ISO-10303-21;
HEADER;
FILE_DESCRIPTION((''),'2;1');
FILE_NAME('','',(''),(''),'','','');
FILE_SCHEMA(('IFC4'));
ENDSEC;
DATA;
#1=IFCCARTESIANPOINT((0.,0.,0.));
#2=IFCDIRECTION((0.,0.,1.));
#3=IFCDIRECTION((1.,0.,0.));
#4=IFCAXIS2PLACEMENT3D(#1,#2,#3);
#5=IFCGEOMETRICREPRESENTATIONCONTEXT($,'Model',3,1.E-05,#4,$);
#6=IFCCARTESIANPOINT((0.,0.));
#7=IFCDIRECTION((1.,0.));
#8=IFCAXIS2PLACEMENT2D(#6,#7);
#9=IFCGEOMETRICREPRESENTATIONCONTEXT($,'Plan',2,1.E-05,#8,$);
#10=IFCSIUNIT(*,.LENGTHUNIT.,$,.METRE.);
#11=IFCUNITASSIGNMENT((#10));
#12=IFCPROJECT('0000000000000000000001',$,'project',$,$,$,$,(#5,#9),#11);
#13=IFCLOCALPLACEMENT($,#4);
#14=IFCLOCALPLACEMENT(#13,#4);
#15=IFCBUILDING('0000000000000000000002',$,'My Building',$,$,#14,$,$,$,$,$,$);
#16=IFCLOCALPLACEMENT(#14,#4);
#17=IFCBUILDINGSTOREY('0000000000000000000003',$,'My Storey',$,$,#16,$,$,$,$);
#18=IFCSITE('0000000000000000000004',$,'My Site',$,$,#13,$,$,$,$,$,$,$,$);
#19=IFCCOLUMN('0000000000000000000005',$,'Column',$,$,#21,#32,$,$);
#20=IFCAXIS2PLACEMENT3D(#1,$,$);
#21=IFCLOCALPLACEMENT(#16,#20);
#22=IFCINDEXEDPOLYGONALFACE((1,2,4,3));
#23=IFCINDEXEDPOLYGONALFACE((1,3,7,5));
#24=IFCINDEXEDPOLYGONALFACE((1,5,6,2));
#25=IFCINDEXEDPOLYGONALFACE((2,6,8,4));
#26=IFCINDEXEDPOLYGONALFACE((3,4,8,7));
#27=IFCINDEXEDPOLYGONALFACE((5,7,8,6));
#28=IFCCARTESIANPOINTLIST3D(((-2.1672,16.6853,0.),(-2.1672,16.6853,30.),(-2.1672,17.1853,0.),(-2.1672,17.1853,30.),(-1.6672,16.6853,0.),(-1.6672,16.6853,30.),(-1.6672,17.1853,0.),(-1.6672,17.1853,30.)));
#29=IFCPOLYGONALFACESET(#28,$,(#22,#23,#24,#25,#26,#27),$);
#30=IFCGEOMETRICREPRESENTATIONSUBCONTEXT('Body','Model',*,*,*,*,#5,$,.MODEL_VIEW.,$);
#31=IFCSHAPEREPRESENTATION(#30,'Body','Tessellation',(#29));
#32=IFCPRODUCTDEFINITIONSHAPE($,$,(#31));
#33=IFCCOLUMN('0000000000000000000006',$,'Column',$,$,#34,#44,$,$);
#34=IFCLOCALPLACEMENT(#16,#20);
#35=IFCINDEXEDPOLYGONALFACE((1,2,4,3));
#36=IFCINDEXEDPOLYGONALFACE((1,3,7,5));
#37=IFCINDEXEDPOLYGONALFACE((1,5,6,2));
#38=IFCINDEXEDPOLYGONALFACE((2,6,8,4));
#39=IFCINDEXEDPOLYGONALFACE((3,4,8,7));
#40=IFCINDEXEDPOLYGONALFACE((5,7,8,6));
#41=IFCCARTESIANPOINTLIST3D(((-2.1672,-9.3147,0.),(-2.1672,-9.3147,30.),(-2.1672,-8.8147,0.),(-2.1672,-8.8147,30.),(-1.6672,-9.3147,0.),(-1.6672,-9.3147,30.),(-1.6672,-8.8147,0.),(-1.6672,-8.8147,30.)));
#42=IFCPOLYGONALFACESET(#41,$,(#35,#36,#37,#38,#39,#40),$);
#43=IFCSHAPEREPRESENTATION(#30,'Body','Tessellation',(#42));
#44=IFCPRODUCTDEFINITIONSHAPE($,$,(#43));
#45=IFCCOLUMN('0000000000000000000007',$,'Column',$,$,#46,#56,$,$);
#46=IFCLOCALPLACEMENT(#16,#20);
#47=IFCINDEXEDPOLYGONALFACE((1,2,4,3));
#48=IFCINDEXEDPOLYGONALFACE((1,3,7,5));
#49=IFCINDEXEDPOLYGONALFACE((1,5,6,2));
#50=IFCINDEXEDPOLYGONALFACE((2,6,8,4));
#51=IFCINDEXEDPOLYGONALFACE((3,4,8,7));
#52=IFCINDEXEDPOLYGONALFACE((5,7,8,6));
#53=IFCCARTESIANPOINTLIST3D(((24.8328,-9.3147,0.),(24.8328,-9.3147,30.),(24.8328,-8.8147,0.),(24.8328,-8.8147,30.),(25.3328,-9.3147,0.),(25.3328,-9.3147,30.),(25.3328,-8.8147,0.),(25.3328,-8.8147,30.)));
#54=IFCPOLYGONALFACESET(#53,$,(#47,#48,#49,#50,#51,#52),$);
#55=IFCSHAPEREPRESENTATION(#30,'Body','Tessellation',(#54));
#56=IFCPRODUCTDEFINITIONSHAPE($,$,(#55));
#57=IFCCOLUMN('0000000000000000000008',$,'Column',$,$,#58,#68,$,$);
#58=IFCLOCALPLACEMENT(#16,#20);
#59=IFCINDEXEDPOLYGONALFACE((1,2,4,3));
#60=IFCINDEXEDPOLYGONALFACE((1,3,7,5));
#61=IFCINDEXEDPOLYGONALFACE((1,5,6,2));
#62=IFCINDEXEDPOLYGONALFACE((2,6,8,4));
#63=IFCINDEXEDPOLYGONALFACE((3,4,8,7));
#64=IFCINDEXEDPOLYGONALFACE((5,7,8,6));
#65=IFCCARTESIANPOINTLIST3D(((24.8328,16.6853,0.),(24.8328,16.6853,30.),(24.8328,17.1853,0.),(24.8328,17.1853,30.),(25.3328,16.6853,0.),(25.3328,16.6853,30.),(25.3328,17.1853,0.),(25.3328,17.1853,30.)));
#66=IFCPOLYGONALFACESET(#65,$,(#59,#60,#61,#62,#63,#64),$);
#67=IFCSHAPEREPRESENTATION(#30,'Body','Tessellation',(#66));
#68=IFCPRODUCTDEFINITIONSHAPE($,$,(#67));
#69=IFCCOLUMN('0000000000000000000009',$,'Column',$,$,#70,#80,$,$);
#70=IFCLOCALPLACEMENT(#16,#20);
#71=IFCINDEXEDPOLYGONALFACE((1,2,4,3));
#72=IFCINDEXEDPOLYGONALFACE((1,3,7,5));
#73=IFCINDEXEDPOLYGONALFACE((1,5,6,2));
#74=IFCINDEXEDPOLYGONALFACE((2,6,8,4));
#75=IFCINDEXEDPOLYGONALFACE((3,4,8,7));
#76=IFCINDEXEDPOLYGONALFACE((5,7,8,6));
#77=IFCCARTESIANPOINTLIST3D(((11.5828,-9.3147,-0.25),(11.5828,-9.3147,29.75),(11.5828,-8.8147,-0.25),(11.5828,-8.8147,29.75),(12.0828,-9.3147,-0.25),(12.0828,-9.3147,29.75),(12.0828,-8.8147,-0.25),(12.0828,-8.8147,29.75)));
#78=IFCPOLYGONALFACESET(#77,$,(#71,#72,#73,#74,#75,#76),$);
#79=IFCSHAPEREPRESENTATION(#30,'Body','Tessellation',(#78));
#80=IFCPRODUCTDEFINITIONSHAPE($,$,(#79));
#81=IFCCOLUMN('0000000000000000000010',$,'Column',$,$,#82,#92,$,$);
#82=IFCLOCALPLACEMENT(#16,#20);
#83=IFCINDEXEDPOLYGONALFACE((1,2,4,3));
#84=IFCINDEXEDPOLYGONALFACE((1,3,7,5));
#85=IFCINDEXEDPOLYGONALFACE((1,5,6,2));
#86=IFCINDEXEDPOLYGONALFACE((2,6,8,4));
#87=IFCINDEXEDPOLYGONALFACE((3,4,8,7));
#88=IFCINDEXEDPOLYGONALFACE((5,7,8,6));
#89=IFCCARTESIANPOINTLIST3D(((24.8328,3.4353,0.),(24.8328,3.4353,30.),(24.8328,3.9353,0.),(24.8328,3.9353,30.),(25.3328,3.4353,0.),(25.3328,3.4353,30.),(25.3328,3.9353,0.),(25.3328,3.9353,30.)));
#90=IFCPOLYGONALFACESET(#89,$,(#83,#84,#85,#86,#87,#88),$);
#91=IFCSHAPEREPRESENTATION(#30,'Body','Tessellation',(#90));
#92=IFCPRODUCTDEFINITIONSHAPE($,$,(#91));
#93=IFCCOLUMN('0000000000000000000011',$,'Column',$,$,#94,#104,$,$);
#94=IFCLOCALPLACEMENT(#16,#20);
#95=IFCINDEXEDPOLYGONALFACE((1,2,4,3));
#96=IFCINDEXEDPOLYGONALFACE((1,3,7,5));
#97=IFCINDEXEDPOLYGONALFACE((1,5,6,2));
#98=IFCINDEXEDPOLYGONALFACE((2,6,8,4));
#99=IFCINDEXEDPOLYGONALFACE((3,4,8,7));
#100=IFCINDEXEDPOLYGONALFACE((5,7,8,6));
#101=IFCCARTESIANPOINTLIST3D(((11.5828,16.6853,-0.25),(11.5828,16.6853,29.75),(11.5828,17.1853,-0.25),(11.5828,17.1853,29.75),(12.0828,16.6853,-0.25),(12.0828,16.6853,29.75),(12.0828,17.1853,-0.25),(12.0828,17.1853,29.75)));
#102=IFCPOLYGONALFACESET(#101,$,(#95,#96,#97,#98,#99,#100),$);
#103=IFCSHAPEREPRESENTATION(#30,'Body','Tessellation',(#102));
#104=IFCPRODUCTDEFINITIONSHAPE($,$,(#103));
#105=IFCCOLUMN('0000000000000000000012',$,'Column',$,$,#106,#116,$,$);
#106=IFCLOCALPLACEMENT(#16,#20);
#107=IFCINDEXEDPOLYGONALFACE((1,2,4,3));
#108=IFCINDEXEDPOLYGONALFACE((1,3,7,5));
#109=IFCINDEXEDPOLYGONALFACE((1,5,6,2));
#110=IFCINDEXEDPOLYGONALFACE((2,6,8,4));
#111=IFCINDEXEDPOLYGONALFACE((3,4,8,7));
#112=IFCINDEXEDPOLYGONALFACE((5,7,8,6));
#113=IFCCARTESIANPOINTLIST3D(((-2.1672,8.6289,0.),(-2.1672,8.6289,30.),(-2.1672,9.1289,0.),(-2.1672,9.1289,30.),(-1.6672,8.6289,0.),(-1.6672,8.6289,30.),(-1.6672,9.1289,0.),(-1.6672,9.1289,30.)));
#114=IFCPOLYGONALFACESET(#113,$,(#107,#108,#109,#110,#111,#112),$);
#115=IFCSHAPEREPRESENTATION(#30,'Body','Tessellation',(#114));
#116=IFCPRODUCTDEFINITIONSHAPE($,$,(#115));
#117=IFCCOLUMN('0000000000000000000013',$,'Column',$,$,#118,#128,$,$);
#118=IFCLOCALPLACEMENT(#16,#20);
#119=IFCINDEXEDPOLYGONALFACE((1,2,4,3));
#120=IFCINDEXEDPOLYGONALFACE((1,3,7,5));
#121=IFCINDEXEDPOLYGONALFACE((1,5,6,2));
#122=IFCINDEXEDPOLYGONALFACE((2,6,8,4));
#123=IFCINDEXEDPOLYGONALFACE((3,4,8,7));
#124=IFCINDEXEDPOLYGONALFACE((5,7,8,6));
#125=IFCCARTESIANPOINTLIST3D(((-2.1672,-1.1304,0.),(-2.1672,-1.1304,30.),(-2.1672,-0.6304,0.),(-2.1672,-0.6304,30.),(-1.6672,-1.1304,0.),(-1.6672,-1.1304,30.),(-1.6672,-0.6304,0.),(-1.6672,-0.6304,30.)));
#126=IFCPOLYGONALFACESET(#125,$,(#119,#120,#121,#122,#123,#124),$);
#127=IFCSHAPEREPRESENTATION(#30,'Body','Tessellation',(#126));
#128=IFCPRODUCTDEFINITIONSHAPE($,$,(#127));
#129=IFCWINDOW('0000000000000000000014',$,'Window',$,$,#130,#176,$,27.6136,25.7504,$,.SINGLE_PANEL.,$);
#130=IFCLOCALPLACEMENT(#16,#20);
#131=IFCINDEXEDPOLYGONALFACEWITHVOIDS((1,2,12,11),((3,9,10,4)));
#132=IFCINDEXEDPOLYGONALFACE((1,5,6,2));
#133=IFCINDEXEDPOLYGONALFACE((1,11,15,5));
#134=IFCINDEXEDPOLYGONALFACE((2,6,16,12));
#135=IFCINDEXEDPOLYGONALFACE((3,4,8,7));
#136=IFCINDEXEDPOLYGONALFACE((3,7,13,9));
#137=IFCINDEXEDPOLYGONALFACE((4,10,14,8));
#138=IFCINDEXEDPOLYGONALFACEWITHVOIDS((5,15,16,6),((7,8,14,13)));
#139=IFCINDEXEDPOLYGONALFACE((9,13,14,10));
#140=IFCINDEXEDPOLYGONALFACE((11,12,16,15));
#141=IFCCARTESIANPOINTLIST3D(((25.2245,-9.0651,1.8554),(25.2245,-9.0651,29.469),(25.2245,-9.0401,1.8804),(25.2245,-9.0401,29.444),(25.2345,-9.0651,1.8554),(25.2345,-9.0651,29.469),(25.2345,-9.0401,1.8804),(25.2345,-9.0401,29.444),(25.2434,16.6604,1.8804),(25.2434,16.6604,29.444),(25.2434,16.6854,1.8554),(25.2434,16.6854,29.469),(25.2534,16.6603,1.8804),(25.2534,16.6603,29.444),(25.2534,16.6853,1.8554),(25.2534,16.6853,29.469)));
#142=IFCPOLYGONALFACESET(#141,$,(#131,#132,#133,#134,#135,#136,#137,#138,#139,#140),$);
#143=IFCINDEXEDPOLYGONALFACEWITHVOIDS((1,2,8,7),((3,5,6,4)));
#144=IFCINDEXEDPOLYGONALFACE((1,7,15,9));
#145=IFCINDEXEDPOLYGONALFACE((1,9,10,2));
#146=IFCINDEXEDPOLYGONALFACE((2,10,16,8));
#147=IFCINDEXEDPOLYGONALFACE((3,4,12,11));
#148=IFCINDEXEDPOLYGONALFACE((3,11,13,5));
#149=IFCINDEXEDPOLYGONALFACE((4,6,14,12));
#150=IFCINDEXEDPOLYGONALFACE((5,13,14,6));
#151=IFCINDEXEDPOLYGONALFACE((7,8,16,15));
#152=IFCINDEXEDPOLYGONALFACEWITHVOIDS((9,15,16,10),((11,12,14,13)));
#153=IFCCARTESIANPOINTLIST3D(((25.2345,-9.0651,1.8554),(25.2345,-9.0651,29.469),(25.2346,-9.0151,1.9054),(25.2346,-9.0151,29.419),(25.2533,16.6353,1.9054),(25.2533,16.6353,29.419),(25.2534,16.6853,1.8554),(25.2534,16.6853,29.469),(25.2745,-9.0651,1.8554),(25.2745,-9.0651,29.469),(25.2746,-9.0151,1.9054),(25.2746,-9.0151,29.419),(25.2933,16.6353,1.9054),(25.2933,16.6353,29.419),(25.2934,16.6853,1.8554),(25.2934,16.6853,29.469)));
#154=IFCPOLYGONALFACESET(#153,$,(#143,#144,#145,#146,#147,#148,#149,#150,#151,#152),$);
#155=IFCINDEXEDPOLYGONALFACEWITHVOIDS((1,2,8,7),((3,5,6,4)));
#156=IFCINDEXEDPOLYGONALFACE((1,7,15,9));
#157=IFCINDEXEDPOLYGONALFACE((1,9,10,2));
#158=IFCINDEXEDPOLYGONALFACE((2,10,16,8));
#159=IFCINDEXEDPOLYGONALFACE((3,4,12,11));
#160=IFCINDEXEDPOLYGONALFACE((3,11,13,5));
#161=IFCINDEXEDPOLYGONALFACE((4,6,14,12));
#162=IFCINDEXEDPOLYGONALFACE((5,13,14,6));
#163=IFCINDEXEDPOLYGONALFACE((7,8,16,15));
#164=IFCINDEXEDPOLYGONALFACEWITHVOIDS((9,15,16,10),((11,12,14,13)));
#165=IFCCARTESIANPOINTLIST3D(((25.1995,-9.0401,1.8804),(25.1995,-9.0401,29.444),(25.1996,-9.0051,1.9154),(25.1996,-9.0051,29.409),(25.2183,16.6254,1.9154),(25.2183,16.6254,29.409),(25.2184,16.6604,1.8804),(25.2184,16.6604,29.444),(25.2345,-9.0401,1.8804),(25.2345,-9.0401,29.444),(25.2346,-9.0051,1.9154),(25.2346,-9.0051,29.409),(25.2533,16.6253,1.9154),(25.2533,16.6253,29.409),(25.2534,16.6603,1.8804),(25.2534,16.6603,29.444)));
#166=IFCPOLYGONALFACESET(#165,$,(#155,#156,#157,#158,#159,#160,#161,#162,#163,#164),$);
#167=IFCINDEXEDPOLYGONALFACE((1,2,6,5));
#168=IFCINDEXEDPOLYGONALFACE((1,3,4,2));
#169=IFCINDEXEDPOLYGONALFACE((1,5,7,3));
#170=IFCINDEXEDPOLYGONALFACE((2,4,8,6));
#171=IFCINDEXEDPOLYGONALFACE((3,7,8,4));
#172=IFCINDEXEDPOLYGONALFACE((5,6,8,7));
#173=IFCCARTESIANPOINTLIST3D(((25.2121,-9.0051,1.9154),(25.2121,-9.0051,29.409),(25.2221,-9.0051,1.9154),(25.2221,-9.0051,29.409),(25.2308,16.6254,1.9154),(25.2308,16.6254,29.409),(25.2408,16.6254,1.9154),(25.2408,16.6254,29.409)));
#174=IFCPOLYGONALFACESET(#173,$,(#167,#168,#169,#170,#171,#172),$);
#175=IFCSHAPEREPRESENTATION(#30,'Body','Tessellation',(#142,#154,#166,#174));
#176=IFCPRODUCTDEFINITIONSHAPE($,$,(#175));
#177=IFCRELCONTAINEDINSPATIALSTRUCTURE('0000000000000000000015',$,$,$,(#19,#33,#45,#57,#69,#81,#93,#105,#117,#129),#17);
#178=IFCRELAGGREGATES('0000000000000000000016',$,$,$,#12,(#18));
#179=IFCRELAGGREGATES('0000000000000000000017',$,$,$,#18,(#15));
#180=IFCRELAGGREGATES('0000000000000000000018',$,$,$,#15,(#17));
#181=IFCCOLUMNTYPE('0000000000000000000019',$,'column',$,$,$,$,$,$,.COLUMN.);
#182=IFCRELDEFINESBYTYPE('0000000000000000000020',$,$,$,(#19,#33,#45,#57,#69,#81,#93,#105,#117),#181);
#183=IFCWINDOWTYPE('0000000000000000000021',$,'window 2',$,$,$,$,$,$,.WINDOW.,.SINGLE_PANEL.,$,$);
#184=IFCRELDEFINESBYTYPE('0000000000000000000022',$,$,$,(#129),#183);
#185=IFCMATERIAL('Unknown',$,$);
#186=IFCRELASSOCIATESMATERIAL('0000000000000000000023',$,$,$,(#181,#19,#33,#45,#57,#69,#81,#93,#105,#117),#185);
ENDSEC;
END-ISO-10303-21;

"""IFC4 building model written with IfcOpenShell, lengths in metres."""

from ifc_helpers import new_model, entity, si_unit, frame, origin_with_axes, origin_2d_with_axis, place, context, subcontext, project, spatial, line, indexed_curve, rectangle, outline, extrude, shape, source, transform, mapped, material, material_profile, profile_set, profile_usage, type_object, type_shapes, element, save


model = new_model("IFC4")

# Units and contexts
model_context = context("Model", 3, precision=1e-05, world=origin_with_axes())
plan_context = context("Plan", 2, precision=1e-05, world=origin_2d_with_axis())
body_context_1 = subcontext(model_context, "Body", "Model", "MODEL_VIEW")
body_context_2 = subcontext(plan_context, "Body", "Plan", "PLAN_VIEW")
ifc_project = project(units=[si_unit("LENGTHUNIT", "METRE")], contexts=[model_context, plan_context])

# Site, building, storey
site_placement = place(None, origin_with_axes())
site = spatial("IfcSite", under=ifc_project, at=site_placement, Name="My Site")
building_placement = place(site_placement, origin_with_axes())
building = spatial("IfcBuilding", under=site, at=building_placement, Name="My Building")
storey_placement = place(building_placement, origin_with_axes())
storey = spatial("IfcBuildingStorey", under=building, at=storey_placement, Name="My Storey")

# Columns
ifc_material = material(Name="Unknown")
ifc_material_profile = material_profile(ifc_material, rectangle(XDim=0.5, YDim=0.5))
ifc_profile_set = profile_set([ifc_material_profile])
ifc_profile_usage_1 = profile_usage(ifc_profile_set, cardinal=5)
column_type = type_object("IfcColumnType", Name="column", PredefinedType="COLUMN", material=ifc_profile_set)
column_1_placement = place(storey_placement, frame((-1.9172, 16.9353, 0.0), z_axis=(0.0, 0.0, 1.0), x_axis=(1.0, 0.0, 0.0)))
element("IfcColumn", 1, at=column_1_placement, inside=storey, type_object=column_type, material=ifc_profile_usage_1, Name="Column", context=body_context_1, shape_type="SweptSolid", body=[
    extrude(rectangle(XDim=0.5, YDim=0.5), origin_with_axes(), (0.0, 0.0, 1.0), 30.0),
])
ifc_profile_usage_2 = profile_usage(ifc_profile_set, cardinal=5)
column_2_placement = place(storey_placement, frame((-1.9172, -9.0647, 0.0), z_axis=(0.0, 0.0, 1.0), x_axis=(1.0, 0.0, 0.0)))
element("IfcColumn", 2, at=column_2_placement, inside=storey, type_object=column_type, material=ifc_profile_usage_2, Name="Column", context=body_context_1, shape_type="SweptSolid", body=[
    extrude(rectangle(XDim=0.5, YDim=0.5), origin_with_axes(), (0.0, 0.0, 1.0), 30.0),
])
ifc_profile_usage_3 = profile_usage(ifc_profile_set, cardinal=5)
column_3_placement = place(storey_placement, frame((25.0828, -9.0647, 0.0), z_axis=(0.0, 0.0, 1.0), x_axis=(1.0, 0.0, 0.0)))
element("IfcColumn", 3, at=column_3_placement, inside=storey, type_object=column_type, material=ifc_profile_usage_3, Name="Column", context=body_context_1, shape_type="SweptSolid", body=[
    extrude(rectangle(XDim=0.5, YDim=0.5), origin_with_axes(), (0.0, 0.0, 1.0), 30.0),
])
ifc_profile_usage_4 = profile_usage(ifc_profile_set, cardinal=5)
column_4_placement = place(storey_placement, frame((25.0828, 16.9353, 0.0), z_axis=(0.0, 0.0, 1.0), x_axis=(1.0, 0.0, 0.0)))
element("IfcColumn", 4, at=column_4_placement, inside=storey, type_object=column_type, material=ifc_profile_usage_4, Name="Column", context=body_context_1, shape_type="SweptSolid", body=[
    extrude(rectangle(XDim=0.5, YDim=0.5), origin_with_axes(), (0.0, 0.0, 1.0), 30.0),
])
ifc_profile_usage_5 = profile_usage(ifc_profile_set, cardinal=5)
column_5_placement = place(storey_placement, frame((11.8328, -9.0647, -0.25), z_axis=(0.0, 0.0, 1.0), x_axis=(1.0, 0.0, 0.0)))
element("IfcColumn", 5, at=column_5_placement, inside=storey, type_object=column_type, material=ifc_profile_usage_5, Name="Column", context=body_context_1, shape_type="SweptSolid", body=[
    extrude(rectangle(XDim=0.5, YDim=0.5), origin_with_axes(), (0.0, 0.0, 1.0), 30.0),
])
ifc_profile_usage_6 = profile_usage(ifc_profile_set, cardinal=5)
column_6_placement = place(storey_placement, frame((25.0828, 3.6853, 0.0), z_axis=(0.0, 0.0, 1.0), x_axis=(1.0, 0.0, 0.0)))
element("IfcColumn", 6, at=column_6_placement, inside=storey, type_object=column_type, material=ifc_profile_usage_6, Name="Column", context=body_context_1, shape_type="SweptSolid", body=[
    extrude(rectangle(XDim=0.5, YDim=0.5), origin_with_axes(), (0.0, 0.0, 1.0), 30.0),
])
ifc_profile_usage_7 = profile_usage(ifc_profile_set, cardinal=5)
column_7_placement = place(storey_placement, frame((11.8328, 16.9353, -0.25), z_axis=(0.0, 0.0, 1.0), x_axis=(1.0, 0.0, 0.0)))
element("IfcColumn", 7, at=column_7_placement, inside=storey, type_object=column_type, material=ifc_profile_usage_7, Name="Column", context=body_context_1, shape_type="SweptSolid", body=[
    extrude(rectangle(XDim=0.5, YDim=0.5), origin_with_axes(), (0.0, 0.0, 1.0), 30.0),
])
ifc_profile_usage_8 = profile_usage(ifc_profile_set, cardinal=5)
column_8_placement = place(storey_placement, frame((-1.9172, 8.8789, 0.0), z_axis=(0.0, 0.0, 1.0), x_axis=(1.0, 0.0, 0.0)))
element("IfcColumn", 8, at=column_8_placement, inside=storey, type_object=column_type, material=ifc_profile_usage_8, Name="Column", context=body_context_1, shape_type="SweptSolid", body=[
    extrude(rectangle(XDim=0.5, YDim=0.5), origin_with_axes(), (0.0, 0.0, 1.0), 30.0),
])
ifc_profile_usage_9 = profile_usage(ifc_profile_set, cardinal=5)
column_9_placement = place(storey_placement, frame((-1.9172, -0.8804, 0.0), z_axis=(0.0, 0.0, 1.0), x_axis=(1.0, 0.0, 0.0)))
element("IfcColumn", 9, at=column_9_placement, inside=storey, type_object=column_type, material=ifc_profile_usage_9, Name="Column", context=body_context_1, shape_type="SweptSolid", body=[
    extrude(rectangle(XDim=0.5, YDim=0.5), origin_with_axes(), (0.0, 0.0, 1.0), 30.0),
])

# Window
window_type = type_object("IfcWindowType", Name="window 2", PartitioningType="SINGLE_PANEL", PredefinedType="WINDOW")
shared_shape_1 = source(origin_with_axes(), body_context_1, "Body", "SweptSolid", [
    extrude(outline(indexed_curve([(0.0, 0.0), (25.7504, 0.0), (25.7504, 27.6136), (0.0, 27.6136)], segments=[line(1, 2, 3, 4, 1)]), holes=[indexed_curve([(0.025, 0.025), (25.7254, 0.025), (25.7254, 27.5886), (0.025, 27.5886)], segments=[line(1, 2, 3, 4, 1)])]), frame((0.0, 0.09, 0.0), z_axis=(0.0, -1.0, 0.0), x_axis=(1.0, 0.0, 0.0)), (0.0, 0.0, -1.0), 0.01),
    extrude(outline(indexed_curve([(0.0, 0.0), (25.7504, 0.0), (25.7504, 27.6136), (0.0, 27.6136)], segments=[line(1, 2, 3, 4, 1)]), holes=[indexed_curve([(0.05, 0.05), (25.7004, 0.05), (25.7004, 27.5636), (0.05, 27.5636)], segments=[line(1, 2, 3, 4, 1)])]), frame((0.0, 0.05, 0.0), z_axis=(0.0, -1.0, 0.0), x_axis=(1.0, 0.0, 0.0)), (0.0, 0.0, -1.0), 0.04),
    extrude(outline(indexed_curve([(0.0, 0.0), (25.7004, 0.0), (25.7004, 27.5636), (0.0, 27.5636)], segments=[line(1, 2, 3, 4, 1)]), holes=[indexed_curve([(0.035, 0.035), (25.6654, 0.035), (25.6654, 27.5286), (0.035, 27.5286)], segments=[line(1, 2, 3, 4, 1)])]), frame((0.025, 0.09, 0.025), z_axis=(0.0, -1.0, 0.0), x_axis=(1.0, 0.0, 0.0)), (0.0, 0.0, -1.0), 0.035),
    extrude(outline(indexed_curve([(0.035, 0.035), (25.6654, 0.035), (25.6654, 27.5286), (0.035, 27.5286)], segments=[line(1, 2, 3, 4, 1)])), frame((0.025, 0.1025, 0.025), z_axis=(0.0, -1.0, 0.0), x_axis=(1.0, 0.0, 0.0)), (0.0, 0.0, -1.0), 0.01),
])
shared_shape_2 = source(origin_with_axes(), body_context_2, "Body", "Curve2D", [
    entity("IfcIndexedPolyCurve", entity("IfcCartesianPointList2D", [[0.05, 0.05], [25.7004, 0.05]])),
    entity("IfcIndexedPolyCurve", entity("IfcCartesianPointList2D", [[0.0, 0.1], [0.025, 0.1], [0.025, 0.09], [0.05, 0.09], [0.05, 0.05], [0.0, 0.05]]), [entity("IfcLineIndex", [1, 2, 3, 4, 5, 6, 1])]),
    entity("IfcIndexedPolyCurve", entity("IfcCartesianPointList2D", [[25.7504, 0.1], [25.7254, 0.1], [25.7254, 0.09], [25.7004, 0.09], [25.7004, 0.05], [25.7504, 0.05]]), [entity("IfcLineIndex", [1, 2, 3, 4, 5, 6, 1])]),
    entity("IfcIndexedPolyCurve", entity("IfcCartesianPointList2D", [[0.025, 0.09], [0.06, 0.09], [0.06, 0.125], [0.025, 0.125]]), [entity("IfcLineIndex", [1, 2, 3, 4, 1])]),
    entity("IfcIndexedPolyCurve", entity("IfcCartesianPointList2D", [[25.7254, 0.09], [25.6904, 0.09], [25.6904, 0.125], [25.7254, 0.125]]), [entity("IfcLineIndex", [1, 2, 3, 4, 1])]),
    entity("IfcIndexedPolyCurve", entity("IfcCartesianPointList2D", [[0.06, 0.09], [25.6904, 0.09]])),
    entity("IfcIndexedPolyCurve", entity("IfcCartesianPointList2D", [[0.06, 0.125], [25.6904, 0.125]])),
    entity("IfcIndexedPolyCurve", entity("IfcCartesianPointList2D", [[0.06, 0.1075], [25.6904, 0.1075]])),
])
type_shapes(window_type, [shared_shape_1, shared_shape_2])
window_placement = place(storey_placement, frame((25.3245, -9.0652, 1.8554), z_axis=(0.0, 0.0, 1.0), x_axis=(0.000732, 1.0, 0.0)))
element("IfcWindow", 10, at=window_placement, inside=storey, type_object=window_type, Name="Window", OverallHeight=27.6136, OverallWidth=25.7504, PartitioningType="SINGLE_PANEL", shapes=[
    shape(body_context_1, "Body", "MappedRepresentation", [mapped(shared_shape_1, transform((0.0, 0.0, 0.0), x_axis=(1.0, 0.0, 0.0), y_axis=(0.0, 1.0, 0.0), z_axis=(0.0, 0.0, 1.0), scale=1.0))]),
    shape(body_context_2, "Body", "MappedRepresentation", [mapped(shared_shape_2, transform((0.0, 0.0, 0.0), x_axis=(1.0, 0.0, 0.0), y_axis=(0.0, 1.0, 0.0), z_axis=(0.0, 0.0, 1.0), scale=1.0))]),
])

save(model, "model.ifc")
